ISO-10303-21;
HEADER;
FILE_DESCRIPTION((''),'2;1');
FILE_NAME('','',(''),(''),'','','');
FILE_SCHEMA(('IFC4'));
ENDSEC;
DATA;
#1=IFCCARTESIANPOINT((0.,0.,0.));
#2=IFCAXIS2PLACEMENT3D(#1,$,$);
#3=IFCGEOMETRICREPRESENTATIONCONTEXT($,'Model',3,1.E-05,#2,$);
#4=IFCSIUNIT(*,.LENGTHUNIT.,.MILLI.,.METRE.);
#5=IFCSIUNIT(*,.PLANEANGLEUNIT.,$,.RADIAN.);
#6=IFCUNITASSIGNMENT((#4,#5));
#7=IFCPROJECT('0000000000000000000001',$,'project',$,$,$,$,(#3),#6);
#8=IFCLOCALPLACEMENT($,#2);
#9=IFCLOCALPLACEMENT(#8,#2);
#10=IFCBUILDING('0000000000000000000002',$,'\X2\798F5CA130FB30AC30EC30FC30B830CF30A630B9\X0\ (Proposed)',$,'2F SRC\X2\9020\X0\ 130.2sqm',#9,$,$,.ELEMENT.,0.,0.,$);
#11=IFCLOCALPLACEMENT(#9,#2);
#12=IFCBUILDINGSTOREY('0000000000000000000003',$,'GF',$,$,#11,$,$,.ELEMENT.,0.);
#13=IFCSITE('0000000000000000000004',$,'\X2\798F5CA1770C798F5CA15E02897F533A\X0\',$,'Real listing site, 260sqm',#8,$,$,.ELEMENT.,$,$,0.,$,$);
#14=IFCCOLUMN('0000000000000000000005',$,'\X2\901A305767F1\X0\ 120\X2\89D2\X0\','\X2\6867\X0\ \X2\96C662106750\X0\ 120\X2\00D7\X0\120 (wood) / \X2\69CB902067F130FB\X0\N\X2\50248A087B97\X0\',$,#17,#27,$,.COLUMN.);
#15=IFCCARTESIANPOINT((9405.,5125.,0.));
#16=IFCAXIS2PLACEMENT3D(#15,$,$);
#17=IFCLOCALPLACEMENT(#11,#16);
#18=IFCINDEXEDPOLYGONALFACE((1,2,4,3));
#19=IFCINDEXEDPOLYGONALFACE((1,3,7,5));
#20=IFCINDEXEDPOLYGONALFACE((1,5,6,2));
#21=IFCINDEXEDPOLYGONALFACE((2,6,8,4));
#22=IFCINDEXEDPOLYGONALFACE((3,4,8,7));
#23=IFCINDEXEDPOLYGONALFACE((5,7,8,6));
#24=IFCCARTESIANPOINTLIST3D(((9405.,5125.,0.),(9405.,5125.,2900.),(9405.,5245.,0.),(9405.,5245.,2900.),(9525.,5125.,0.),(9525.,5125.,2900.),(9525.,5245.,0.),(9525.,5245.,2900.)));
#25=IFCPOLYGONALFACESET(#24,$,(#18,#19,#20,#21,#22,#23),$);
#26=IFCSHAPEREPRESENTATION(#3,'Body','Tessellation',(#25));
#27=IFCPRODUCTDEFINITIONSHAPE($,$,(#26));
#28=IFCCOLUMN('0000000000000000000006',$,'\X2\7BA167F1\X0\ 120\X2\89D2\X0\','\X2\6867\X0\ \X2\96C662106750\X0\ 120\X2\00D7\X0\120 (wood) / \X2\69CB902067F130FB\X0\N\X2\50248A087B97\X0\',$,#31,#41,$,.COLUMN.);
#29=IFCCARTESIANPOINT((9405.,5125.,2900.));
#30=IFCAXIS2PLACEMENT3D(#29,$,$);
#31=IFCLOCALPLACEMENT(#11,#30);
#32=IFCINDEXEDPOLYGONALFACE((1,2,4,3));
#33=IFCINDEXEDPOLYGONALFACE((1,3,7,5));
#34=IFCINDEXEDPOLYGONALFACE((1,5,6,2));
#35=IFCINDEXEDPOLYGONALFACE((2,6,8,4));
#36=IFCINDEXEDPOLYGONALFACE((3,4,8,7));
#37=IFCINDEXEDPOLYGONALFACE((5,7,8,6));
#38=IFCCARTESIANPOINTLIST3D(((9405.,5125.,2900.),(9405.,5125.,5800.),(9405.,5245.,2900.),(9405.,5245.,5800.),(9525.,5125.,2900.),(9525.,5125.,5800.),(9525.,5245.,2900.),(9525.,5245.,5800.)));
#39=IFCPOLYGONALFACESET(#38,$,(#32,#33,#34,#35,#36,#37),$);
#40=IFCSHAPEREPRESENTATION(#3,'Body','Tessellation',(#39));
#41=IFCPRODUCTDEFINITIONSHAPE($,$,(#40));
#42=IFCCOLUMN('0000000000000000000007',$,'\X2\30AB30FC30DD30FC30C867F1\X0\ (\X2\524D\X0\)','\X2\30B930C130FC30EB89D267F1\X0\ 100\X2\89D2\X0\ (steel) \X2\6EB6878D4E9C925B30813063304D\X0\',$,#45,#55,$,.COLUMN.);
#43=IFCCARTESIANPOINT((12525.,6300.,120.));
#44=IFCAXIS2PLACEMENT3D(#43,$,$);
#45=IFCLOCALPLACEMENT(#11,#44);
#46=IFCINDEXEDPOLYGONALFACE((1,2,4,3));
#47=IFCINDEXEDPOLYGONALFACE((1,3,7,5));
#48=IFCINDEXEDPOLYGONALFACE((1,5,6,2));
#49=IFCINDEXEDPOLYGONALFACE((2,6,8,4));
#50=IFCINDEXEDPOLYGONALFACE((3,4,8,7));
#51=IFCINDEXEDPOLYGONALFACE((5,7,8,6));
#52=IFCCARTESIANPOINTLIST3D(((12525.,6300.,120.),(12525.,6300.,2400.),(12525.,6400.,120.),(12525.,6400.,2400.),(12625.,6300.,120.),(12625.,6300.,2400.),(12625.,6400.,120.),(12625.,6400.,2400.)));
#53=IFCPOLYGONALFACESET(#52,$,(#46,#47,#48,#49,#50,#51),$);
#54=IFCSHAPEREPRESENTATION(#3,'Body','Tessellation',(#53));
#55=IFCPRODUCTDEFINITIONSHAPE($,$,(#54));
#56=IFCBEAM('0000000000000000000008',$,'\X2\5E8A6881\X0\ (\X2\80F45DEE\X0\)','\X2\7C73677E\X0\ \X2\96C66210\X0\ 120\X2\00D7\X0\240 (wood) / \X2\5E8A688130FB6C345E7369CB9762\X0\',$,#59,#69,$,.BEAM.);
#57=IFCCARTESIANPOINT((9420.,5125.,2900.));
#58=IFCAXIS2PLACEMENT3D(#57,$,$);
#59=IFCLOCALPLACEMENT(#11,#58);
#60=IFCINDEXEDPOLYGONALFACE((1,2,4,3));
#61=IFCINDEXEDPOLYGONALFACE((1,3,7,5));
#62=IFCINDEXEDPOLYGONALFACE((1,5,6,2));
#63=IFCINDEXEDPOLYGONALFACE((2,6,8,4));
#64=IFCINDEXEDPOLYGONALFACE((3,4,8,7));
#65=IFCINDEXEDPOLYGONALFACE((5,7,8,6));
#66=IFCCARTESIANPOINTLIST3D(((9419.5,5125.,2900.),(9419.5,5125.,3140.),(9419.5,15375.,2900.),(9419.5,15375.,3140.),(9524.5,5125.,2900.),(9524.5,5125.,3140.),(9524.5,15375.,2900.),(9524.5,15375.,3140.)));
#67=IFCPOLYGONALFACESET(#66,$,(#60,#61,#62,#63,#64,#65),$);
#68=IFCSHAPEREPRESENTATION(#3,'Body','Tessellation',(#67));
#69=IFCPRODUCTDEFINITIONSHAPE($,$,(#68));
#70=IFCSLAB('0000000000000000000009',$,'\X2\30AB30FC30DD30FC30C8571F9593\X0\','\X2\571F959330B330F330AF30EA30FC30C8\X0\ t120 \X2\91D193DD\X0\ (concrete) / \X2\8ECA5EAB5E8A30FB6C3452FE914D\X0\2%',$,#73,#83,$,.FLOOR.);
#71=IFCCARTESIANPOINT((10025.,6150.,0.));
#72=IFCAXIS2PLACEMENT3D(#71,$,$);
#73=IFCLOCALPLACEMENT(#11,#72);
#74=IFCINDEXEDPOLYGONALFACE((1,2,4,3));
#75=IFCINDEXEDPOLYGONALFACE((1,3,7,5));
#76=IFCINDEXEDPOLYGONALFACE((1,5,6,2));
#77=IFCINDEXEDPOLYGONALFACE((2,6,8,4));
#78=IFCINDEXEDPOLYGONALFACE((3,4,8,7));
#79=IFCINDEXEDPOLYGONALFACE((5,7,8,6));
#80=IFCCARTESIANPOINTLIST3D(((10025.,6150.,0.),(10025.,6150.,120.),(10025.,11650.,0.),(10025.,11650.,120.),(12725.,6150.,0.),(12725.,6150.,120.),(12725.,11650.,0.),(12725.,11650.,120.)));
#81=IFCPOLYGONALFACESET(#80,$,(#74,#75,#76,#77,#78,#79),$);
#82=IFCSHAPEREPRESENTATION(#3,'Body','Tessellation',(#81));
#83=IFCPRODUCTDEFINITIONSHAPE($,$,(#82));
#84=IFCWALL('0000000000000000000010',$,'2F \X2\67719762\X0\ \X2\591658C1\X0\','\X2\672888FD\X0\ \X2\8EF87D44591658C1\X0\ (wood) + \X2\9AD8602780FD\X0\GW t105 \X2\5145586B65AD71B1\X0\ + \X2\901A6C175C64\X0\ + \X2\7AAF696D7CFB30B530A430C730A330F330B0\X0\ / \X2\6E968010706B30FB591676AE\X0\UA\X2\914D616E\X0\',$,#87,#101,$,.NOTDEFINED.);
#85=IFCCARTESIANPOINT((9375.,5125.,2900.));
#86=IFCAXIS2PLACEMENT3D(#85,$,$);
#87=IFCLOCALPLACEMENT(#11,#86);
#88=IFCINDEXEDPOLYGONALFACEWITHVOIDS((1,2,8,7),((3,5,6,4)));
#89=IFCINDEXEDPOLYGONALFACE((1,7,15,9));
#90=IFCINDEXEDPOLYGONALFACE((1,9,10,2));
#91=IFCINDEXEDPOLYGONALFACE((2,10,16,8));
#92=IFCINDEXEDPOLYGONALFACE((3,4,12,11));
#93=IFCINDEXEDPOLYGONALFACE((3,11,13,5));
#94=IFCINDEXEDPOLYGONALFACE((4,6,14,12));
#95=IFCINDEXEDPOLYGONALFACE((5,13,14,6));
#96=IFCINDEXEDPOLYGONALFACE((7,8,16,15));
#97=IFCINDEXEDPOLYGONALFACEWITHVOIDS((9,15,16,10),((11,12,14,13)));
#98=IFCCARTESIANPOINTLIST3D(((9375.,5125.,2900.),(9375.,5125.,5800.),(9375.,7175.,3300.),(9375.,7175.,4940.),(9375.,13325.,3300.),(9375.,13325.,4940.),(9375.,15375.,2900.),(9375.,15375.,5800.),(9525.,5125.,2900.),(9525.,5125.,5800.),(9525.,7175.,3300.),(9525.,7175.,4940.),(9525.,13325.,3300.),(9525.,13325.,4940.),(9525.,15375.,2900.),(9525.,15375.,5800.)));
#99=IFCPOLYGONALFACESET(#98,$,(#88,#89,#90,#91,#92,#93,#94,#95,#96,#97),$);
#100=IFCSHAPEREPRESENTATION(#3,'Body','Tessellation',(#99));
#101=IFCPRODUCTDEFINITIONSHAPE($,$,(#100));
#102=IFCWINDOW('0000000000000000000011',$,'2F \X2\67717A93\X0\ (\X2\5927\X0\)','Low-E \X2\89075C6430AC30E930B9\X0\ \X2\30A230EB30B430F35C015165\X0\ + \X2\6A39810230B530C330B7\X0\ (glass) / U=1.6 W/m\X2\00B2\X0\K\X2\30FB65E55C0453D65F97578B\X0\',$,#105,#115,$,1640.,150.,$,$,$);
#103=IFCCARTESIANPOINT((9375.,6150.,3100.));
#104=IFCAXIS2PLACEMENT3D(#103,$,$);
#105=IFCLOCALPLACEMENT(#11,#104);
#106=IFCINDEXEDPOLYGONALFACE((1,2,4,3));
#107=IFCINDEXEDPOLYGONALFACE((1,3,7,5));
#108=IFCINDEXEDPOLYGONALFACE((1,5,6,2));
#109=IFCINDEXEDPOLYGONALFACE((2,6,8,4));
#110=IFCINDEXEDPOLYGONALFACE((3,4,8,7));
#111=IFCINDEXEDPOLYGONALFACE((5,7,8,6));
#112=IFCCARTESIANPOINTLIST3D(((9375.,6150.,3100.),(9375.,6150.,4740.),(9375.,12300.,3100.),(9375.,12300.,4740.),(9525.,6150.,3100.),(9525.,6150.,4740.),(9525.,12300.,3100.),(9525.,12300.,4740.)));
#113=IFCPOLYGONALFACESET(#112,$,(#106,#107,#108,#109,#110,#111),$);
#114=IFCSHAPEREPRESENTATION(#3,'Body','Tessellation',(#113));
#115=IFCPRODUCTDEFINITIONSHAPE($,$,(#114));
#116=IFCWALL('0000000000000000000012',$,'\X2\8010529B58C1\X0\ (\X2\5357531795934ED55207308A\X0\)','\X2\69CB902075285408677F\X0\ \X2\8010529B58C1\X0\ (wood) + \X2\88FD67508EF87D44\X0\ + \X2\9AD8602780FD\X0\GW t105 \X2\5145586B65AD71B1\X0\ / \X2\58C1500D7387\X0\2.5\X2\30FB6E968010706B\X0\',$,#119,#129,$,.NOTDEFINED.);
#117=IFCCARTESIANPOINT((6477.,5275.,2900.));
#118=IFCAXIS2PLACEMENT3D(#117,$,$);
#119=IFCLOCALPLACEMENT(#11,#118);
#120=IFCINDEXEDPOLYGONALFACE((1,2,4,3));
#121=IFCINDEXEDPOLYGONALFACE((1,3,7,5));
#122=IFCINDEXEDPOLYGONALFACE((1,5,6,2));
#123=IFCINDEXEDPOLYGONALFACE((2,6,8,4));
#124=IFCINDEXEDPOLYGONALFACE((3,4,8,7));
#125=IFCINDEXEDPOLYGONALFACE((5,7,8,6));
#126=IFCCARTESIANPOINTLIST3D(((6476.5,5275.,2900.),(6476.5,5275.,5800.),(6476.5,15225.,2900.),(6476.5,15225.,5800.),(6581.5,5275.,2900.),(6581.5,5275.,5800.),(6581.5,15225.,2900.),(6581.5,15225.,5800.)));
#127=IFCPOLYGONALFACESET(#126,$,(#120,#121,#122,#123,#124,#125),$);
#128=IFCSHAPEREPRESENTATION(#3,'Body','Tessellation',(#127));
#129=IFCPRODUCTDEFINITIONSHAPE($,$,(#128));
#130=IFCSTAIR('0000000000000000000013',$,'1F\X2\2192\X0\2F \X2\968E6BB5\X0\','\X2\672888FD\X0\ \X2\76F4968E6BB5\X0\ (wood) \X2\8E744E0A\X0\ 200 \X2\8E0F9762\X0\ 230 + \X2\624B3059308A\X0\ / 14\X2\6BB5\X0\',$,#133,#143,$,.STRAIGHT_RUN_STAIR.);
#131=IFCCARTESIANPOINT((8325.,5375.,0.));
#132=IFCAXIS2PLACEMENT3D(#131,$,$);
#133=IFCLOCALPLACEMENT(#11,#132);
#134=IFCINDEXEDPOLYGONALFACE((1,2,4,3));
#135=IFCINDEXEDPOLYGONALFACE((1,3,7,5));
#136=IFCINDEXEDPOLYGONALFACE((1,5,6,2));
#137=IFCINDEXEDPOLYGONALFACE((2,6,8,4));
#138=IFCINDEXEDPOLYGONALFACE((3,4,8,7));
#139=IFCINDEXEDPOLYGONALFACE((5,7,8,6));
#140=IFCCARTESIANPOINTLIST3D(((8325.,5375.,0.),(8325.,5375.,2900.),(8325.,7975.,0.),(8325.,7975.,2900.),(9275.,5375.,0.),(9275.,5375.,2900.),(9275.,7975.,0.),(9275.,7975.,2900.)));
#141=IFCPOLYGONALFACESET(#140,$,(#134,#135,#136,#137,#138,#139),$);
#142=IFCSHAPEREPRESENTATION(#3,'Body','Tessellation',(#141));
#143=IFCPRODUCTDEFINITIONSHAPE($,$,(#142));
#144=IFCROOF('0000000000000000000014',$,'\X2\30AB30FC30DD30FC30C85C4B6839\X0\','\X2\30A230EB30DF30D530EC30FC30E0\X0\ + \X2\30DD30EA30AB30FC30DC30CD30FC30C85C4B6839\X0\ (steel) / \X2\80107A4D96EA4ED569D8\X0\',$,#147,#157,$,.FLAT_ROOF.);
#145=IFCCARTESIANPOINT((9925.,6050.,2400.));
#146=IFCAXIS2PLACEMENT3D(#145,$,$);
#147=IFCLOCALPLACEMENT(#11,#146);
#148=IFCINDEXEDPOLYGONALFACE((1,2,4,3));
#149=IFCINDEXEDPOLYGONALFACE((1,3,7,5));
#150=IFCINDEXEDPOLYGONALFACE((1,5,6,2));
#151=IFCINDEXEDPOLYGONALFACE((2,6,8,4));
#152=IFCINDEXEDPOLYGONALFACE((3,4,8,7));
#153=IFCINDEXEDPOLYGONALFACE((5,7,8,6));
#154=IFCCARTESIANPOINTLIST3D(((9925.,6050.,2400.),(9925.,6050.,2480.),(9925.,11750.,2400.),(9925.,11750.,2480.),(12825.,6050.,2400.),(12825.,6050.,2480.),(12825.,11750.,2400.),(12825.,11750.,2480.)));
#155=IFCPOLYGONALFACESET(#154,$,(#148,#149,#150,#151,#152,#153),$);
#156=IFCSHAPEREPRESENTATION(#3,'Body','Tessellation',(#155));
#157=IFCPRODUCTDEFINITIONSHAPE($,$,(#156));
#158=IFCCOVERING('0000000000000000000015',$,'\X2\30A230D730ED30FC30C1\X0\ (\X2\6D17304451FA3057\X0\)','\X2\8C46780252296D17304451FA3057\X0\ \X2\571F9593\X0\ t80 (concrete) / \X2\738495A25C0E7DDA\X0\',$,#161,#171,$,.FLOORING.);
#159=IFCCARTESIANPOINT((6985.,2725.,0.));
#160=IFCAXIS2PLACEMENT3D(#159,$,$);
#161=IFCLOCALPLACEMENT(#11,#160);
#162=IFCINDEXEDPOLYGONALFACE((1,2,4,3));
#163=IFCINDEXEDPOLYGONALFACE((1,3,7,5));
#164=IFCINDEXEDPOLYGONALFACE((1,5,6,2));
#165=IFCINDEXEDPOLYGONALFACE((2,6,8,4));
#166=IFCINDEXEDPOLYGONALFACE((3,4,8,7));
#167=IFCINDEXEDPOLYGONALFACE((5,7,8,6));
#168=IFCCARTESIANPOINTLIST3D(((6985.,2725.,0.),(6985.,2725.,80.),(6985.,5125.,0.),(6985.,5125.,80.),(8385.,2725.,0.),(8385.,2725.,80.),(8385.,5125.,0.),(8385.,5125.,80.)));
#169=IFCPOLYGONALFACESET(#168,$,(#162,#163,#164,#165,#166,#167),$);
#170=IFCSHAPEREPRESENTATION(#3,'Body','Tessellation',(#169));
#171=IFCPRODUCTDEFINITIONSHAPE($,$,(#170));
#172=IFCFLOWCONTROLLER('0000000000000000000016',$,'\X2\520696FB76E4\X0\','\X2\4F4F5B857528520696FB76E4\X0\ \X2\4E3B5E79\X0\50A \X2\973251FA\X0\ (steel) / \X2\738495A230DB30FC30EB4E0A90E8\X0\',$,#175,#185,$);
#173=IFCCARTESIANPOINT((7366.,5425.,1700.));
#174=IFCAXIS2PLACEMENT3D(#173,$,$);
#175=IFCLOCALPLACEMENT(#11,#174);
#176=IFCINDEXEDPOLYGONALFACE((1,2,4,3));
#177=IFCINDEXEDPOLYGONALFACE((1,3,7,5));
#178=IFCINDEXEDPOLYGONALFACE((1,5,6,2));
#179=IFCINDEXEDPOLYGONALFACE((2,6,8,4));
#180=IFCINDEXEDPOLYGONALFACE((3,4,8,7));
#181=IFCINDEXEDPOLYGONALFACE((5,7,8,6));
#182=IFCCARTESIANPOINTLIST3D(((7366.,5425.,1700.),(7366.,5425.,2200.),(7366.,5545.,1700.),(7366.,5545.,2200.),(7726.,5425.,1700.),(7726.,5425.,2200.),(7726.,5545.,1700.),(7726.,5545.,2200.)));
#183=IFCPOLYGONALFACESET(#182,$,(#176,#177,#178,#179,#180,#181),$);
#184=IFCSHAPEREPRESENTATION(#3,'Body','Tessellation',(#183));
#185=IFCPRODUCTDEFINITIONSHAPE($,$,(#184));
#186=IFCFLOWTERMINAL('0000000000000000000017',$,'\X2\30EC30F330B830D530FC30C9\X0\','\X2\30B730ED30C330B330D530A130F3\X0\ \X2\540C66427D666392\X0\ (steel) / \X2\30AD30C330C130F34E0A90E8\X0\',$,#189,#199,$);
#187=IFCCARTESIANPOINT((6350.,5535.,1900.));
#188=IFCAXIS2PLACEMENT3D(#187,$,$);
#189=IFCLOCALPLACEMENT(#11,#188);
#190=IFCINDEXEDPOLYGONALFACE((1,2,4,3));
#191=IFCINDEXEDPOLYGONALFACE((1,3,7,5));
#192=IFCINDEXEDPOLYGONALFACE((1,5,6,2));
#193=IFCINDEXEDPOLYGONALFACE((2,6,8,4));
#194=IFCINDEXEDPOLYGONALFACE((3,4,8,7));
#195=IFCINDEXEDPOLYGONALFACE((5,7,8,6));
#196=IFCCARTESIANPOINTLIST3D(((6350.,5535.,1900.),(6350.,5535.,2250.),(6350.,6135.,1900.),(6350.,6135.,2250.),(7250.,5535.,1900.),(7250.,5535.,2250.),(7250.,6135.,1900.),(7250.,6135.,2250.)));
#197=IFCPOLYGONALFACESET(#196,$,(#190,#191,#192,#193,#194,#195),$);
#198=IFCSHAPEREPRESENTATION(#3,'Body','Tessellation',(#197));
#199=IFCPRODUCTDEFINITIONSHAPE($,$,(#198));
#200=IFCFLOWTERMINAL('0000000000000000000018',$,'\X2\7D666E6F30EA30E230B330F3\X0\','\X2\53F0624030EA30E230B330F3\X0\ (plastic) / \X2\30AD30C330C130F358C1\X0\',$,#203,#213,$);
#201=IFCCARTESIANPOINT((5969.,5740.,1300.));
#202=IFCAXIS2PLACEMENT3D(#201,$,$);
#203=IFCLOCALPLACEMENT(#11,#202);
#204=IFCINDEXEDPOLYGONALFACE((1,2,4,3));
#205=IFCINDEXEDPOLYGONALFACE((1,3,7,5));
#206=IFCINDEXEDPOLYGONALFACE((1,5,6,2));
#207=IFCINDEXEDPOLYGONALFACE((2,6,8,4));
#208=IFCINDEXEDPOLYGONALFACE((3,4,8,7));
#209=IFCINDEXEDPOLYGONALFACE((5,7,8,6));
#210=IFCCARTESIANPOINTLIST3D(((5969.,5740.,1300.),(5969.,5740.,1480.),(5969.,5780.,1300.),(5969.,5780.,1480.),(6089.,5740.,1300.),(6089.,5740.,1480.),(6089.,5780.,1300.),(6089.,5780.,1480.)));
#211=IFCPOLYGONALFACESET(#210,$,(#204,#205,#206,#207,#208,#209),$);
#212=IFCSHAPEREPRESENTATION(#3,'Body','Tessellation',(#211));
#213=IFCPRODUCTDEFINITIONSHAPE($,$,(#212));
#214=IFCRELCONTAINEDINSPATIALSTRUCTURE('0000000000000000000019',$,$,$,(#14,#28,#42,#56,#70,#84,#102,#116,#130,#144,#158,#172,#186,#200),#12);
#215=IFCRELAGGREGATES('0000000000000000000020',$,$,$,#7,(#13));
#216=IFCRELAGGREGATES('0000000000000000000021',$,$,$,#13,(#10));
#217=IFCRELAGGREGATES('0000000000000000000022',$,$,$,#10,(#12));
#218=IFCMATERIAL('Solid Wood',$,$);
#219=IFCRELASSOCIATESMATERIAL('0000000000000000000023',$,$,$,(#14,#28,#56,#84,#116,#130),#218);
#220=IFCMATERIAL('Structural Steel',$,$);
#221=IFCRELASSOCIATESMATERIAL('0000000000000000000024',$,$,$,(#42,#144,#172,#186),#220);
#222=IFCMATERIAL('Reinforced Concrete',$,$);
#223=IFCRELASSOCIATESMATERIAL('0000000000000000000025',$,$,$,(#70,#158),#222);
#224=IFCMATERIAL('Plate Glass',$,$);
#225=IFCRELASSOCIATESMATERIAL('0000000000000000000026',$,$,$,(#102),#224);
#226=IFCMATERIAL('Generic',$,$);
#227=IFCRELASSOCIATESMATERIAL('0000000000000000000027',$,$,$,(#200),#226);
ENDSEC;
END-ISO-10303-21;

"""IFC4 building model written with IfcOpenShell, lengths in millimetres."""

from ifc_helpers import new_model, si_unit, frame, frame_2d, origin, place, context, project, spatial, rectangle, extrude, material, element, fill, save


model = new_model("IFC4")

# Units and contexts
model_context = context("Model", 3, precision=1e-05, world=origin())
ifc_project = project(units=[si_unit("LENGTHUNIT", "METRE", prefix="MILLI"), si_unit("PLANEANGLEUNIT", "RADIAN")], contexts=[model_context])

# Site, building, storey
site_placement = place(None, origin())
site = spatial("IfcSite", under=ifc_project, at=site_placement, Name="福岡県福岡市西区", ObjectType="Real listing site, 260sqm", CompositionType="ELEMENT", RefElevation=0.0)
building_placement = place(site_placement, origin())
building = spatial("IfcBuilding", under=site, at=building_placement, Name="福岡・ガレージハウス (Proposed)", ObjectType="2F SRC造 130.2sqm", CompositionType="ELEMENT", ElevationOfRefHeight=0.0, ElevationOfTerrain=0.0)
storey_placement = place(building_placement, origin())
storey = spatial("IfcBuildingStorey", under=building, at=storey_placement, Name="GF", CompositionType="ELEMENT", Elevation=0.0)

# Columns
ifc_material_1 = material(Name="Solid Wood")
column_1_placement = place(storey_placement, frame((9405.0, 5125.0, 0.0)))
element("IfcColumn", 1, at=column_1_placement, inside=storey, material=ifc_material_1, Name="通し柱 120角", Description="桧 集成材 120×120 (wood) / 構造柱・N値計算", PredefinedType="COLUMN", context=model_context, shape_type="SweptSolid", body=[
    extrude(rectangle(XDim=120.0, YDim=120.0, at=frame_2d((60.0, 60.0))), frame((9405.0, 5125.0, 0.0)), (0.0, 0.0, 1.0), 2900.0),
])
column_2_placement = place(storey_placement, frame((9405.0, 5125.0, 2900.0)))
element("IfcColumn", 2, at=column_2_placement, inside=storey, material=ifc_material_1, Name="管柱 120角", Description="桧 集成材 120×120 (wood) / 構造柱・N値計算", PredefinedType="COLUMN", context=model_context, shape_type="SweptSolid", body=[
    extrude(rectangle(XDim=120.0, YDim=120.0, at=frame_2d((60.0, 60.0))), frame((9405.0, 5125.0, 2900.0)), (0.0, 0.0, 1.0), 2900.0),
])
ifc_material_2 = material(Name="Structural Steel")
column_3_placement = place(storey_placement, frame((12525.0, 6300.0, 120.0)))
element("IfcColumn", 3, at=column_3_placement, inside=storey, material=ifc_material_2, Name="カーポート柱 (前)", Description="スチール角柱 100角 (steel) 溶融亜鉛めっき", PredefinedType="COLUMN", context=model_context, shape_type="SweptSolid", body=[
    extrude(rectangle(XDim=100.0, YDim=100.0, at=frame_2d((50.0, 50.0))), frame((12525.0, 6300.0, 120.0)), (0.0, 0.0, 1.0), 2280.0),
])

# Beam
beam_1_placement = place(storey_placement, frame((9420.0, 5125.0, 2900.0)))
element("IfcBeam", 4, at=beam_1_placement, inside=storey, material=ifc_material_1, Name="床梁 (胴差)", Description="米松 集成 120×240 (wood) / 床梁・水平構面", PredefinedType="BEAM", context=model_context, shape_type="SweptSolid", body=[
    extrude(rectangle(XDim=105.0, YDim=10250.0, at=frame_2d((52.0, 5125.0))), frame((9420.0, 5125.0, 2900.0)), (0.0, 0.0, 1.0), 240.0),
])

# Slab
ifc_material_3 = material(Name="Reinforced Concrete")
slab_placement = place(storey_placement, frame((10025.0, 6150.0, 0.0)))
element("IfcSlab", 5, at=slab_placement, inside=storey, material=ifc_material_3, Name="カーポート土間", Description="土間コンクリート t120 金鏝 (concrete) / 車庫床・水勾配2%", PredefinedType="FLOOR", context=model_context, shape_type="SweptSolid", body=[
    extrude(rectangle(XDim=2700.0, YDim=5500.0, at=frame_2d((1350.0, 2750.0))), frame((10025.0, 6150.0, 0.0)), (0.0, 0.0, 1.0), 120.0),
])

# Shared definitions
ifc_material_4 = material(Name="Plate Glass")

# Wall, opening, window
wall_1_placement = place(storey_placement, frame((9375.0, 5125.0, 2900.0)))
wall_1 = element("IfcWall", 6, at=wall_1_placement, inside=storey, material=ifc_material_1, Name="2F 東面 外壁", Description="木製 軸組外壁 (wood) + 高性能GW t105 充填断熱 + 通気層 + 窯業系サイディング / 準耐火・外皮UA配慮", PredefinedType="NOTDEFINED", context=model_context, shape_type="SweptSolid", body=[
    extrude(rectangle(XDim=150.0, YDim=10250.0, at=frame_2d((75.0, 5125.0))), frame((9375.0, 5125.0, 2900.0)), (0.0, 0.0, 1.0), 2900.0),
])
opening_1_placement = place(storey_placement, frame((9375.0, 6150.0, 3100.0)))
opening_1 = element("IfcOpeningElement", 7, at=opening_1_placement, cuts=wall_1, PredefinedType="NOTDEFINED", context=model_context, shape_type="SweptSolid", body=[
    extrude(rectangle(XDim=150.0, YDim=6150.0, at=frame_2d((75.0, 3075.0))), frame((9375.0, 6150.0, 3100.0)), (0.0, 0.0, 1.0), 1640.0),
])
window_1_placement = place(storey_placement, frame((9375.0, 6150.0, 3100.0)))
window_1 = element("IfcWindow", 8, at=window_1_placement, inside=storey, material=ifc_material_4, Name="2F 東窓 (大)", Description="Low-E 複層ガラス アルゴン封入 + 樹脂サッシ (glass) / U=1.6 W/m²K・日射取得型", OverallHeight=1640.0, OverallWidth=150.0, context=model_context, shape_type="SweptSolid", body=[
    extrude(rectangle(XDim=150.0, YDim=6150.0, at=frame_2d((75.0, 3075.0))), frame((9375.0, 6150.0, 3100.0)), (0.0, 0.0, 1.0), 1640.0),
])
fill(opening_1, window_1)

# Wall
wall_2_placement = place(storey_placement, frame((6477.0, 5275.0, 2900.0)))
element("IfcWall", 9, at=wall_2_placement, inside=storey, material=ifc_material_1, Name="耐力壁 (南北間仕切り)", Description="構造用合板 耐力壁 (wood) + 製材軸組 + 高性能GW t105 充填断熱 / 壁倍率2.5・準耐火", PredefinedType="NOTDEFINED", context=model_context, shape_type="SweptSolid", body=[
    extrude(rectangle(XDim=105.0, YDim=9950.0, at=frame_2d((52.0, 4975.0))), frame((6477.0, 5275.0, 2900.0)), (0.0, 0.0, 1.0), 2900.0),
])

# Stair
stair_placement = place(storey_placement, frame((8325.0, 5375.0, 0.0)))
element("IfcStair", 10, at=stair_placement, inside=storey, material=ifc_material_1, Name="1F→2F 階段", Description="木製 直階段 (wood) 蹴上 200 踏面 230 + 手すり / 14段", PredefinedType="STRAIGHT_RUN_STAIR", context=model_context, shape_type="SweptSolid", body=[
    extrude(rectangle(XDim=950.0, YDim=2600.0, at=frame_2d((475.0, 1300.0))), frame((8325.0, 5375.0, 0.0)), (0.0, 0.0, 1.0), 2900.0),
])

# Roof
roof_placement = place(storey_placement, frame((9925.0, 6050.0, 2400.0)))
element("IfcRoof", 11, at=roof_placement, inside=storey, material=ifc_material_2, Name="カーポート屋根", Description="アルミフレーム + ポリカーボネート屋根 (steel) / 耐積雪仕様", PredefinedType="FLAT_ROOF", context=model_context, shape_type="SweptSolid", body=[
    extrude(rectangle(XDim=2900.0, YDim=5700.0, at=frame_2d((1450.0, 2850.0))), frame((9925.0, 6050.0, 2400.0)), (0.0, 0.0, 1.0), 80.0),
])

# Covering
covering_placement = place(storey_placement, frame((6985.0, 2725.0, 0.0)))
element("IfcCovering", 12, at=covering_placement, inside=storey, material=ifc_material_3, Name="アプローチ (洗い出し)", Description="豆砂利洗い出し 土間 t80 (concrete) / 玄関導線", PredefinedType="FLOORING", context=model_context, shape_type="SweptSolid", body=[
    extrude(rectangle(XDim=1400.0, YDim=2400.0, at=frame_2d((700.0, 1200.0))), frame((6985.0, 2725.0, 0.0)), (0.0, 0.0, 1.0), 80.0),
])

# Flow controller
flow_controller_placement = place(storey_placement, frame((7366.0, 5425.0, 1700.0)))
element("IfcFlowController", 13, at=flow_controller_placement, inside=storey, material=ifc_material_2, Name="分電盤", Description="住宅用分電盤 主幹50A 露出 (steel) / 玄関ホール上部", context=model_context, shape_type="SweptSolid", body=[
    extrude(rectangle(XDim=360.0, YDim=120.0, at=frame_2d((180.0, 60.0))), frame((7366.0, 5425.0, 1700.0)), (0.0, 0.0, 1.0), 500.0),
])

# Flow terminals
flow_terminal_1_placement = place(storey_placement, frame((6350.0, 5535.0, 1900.0)))
element("IfcFlowTerminal", 14, at=flow_terminal_1_placement, inside=storey, material=ifc_material_2, Name="レンジフード", Description="シロッコファン 同時給排 (steel) / キッチン上部", context=model_context, shape_type="SweptSolid", body=[
    extrude(rectangle(XDim=900.0, YDim=600.0, at=frame_2d((450.0, 300.0))), frame((6350.0, 5535.0, 1900.0)), (0.0, 0.0, 1.0), 350.0),
])
ifc_material_5 = material(Name="Generic")
flow_terminal_2_placement = place(storey_placement, frame((5969.0, 5740.0, 1300.0)))
element("IfcFlowTerminal", 15, at=flow_terminal_2_placement, inside=storey, material=ifc_material_5, Name="給湯リモコン", Description="台所リモコン (plastic) / キッチン壁", context=model_context, shape_type="SweptSolid", body=[
    extrude(rectangle(XDim=120.0, YDim=40.0, at=frame_2d((60.0, 20.0))), frame((5969.0, 5740.0, 1300.0)), (0.0, 0.0, 1.0), 180.0),
])

save(model, "model.ifc")
